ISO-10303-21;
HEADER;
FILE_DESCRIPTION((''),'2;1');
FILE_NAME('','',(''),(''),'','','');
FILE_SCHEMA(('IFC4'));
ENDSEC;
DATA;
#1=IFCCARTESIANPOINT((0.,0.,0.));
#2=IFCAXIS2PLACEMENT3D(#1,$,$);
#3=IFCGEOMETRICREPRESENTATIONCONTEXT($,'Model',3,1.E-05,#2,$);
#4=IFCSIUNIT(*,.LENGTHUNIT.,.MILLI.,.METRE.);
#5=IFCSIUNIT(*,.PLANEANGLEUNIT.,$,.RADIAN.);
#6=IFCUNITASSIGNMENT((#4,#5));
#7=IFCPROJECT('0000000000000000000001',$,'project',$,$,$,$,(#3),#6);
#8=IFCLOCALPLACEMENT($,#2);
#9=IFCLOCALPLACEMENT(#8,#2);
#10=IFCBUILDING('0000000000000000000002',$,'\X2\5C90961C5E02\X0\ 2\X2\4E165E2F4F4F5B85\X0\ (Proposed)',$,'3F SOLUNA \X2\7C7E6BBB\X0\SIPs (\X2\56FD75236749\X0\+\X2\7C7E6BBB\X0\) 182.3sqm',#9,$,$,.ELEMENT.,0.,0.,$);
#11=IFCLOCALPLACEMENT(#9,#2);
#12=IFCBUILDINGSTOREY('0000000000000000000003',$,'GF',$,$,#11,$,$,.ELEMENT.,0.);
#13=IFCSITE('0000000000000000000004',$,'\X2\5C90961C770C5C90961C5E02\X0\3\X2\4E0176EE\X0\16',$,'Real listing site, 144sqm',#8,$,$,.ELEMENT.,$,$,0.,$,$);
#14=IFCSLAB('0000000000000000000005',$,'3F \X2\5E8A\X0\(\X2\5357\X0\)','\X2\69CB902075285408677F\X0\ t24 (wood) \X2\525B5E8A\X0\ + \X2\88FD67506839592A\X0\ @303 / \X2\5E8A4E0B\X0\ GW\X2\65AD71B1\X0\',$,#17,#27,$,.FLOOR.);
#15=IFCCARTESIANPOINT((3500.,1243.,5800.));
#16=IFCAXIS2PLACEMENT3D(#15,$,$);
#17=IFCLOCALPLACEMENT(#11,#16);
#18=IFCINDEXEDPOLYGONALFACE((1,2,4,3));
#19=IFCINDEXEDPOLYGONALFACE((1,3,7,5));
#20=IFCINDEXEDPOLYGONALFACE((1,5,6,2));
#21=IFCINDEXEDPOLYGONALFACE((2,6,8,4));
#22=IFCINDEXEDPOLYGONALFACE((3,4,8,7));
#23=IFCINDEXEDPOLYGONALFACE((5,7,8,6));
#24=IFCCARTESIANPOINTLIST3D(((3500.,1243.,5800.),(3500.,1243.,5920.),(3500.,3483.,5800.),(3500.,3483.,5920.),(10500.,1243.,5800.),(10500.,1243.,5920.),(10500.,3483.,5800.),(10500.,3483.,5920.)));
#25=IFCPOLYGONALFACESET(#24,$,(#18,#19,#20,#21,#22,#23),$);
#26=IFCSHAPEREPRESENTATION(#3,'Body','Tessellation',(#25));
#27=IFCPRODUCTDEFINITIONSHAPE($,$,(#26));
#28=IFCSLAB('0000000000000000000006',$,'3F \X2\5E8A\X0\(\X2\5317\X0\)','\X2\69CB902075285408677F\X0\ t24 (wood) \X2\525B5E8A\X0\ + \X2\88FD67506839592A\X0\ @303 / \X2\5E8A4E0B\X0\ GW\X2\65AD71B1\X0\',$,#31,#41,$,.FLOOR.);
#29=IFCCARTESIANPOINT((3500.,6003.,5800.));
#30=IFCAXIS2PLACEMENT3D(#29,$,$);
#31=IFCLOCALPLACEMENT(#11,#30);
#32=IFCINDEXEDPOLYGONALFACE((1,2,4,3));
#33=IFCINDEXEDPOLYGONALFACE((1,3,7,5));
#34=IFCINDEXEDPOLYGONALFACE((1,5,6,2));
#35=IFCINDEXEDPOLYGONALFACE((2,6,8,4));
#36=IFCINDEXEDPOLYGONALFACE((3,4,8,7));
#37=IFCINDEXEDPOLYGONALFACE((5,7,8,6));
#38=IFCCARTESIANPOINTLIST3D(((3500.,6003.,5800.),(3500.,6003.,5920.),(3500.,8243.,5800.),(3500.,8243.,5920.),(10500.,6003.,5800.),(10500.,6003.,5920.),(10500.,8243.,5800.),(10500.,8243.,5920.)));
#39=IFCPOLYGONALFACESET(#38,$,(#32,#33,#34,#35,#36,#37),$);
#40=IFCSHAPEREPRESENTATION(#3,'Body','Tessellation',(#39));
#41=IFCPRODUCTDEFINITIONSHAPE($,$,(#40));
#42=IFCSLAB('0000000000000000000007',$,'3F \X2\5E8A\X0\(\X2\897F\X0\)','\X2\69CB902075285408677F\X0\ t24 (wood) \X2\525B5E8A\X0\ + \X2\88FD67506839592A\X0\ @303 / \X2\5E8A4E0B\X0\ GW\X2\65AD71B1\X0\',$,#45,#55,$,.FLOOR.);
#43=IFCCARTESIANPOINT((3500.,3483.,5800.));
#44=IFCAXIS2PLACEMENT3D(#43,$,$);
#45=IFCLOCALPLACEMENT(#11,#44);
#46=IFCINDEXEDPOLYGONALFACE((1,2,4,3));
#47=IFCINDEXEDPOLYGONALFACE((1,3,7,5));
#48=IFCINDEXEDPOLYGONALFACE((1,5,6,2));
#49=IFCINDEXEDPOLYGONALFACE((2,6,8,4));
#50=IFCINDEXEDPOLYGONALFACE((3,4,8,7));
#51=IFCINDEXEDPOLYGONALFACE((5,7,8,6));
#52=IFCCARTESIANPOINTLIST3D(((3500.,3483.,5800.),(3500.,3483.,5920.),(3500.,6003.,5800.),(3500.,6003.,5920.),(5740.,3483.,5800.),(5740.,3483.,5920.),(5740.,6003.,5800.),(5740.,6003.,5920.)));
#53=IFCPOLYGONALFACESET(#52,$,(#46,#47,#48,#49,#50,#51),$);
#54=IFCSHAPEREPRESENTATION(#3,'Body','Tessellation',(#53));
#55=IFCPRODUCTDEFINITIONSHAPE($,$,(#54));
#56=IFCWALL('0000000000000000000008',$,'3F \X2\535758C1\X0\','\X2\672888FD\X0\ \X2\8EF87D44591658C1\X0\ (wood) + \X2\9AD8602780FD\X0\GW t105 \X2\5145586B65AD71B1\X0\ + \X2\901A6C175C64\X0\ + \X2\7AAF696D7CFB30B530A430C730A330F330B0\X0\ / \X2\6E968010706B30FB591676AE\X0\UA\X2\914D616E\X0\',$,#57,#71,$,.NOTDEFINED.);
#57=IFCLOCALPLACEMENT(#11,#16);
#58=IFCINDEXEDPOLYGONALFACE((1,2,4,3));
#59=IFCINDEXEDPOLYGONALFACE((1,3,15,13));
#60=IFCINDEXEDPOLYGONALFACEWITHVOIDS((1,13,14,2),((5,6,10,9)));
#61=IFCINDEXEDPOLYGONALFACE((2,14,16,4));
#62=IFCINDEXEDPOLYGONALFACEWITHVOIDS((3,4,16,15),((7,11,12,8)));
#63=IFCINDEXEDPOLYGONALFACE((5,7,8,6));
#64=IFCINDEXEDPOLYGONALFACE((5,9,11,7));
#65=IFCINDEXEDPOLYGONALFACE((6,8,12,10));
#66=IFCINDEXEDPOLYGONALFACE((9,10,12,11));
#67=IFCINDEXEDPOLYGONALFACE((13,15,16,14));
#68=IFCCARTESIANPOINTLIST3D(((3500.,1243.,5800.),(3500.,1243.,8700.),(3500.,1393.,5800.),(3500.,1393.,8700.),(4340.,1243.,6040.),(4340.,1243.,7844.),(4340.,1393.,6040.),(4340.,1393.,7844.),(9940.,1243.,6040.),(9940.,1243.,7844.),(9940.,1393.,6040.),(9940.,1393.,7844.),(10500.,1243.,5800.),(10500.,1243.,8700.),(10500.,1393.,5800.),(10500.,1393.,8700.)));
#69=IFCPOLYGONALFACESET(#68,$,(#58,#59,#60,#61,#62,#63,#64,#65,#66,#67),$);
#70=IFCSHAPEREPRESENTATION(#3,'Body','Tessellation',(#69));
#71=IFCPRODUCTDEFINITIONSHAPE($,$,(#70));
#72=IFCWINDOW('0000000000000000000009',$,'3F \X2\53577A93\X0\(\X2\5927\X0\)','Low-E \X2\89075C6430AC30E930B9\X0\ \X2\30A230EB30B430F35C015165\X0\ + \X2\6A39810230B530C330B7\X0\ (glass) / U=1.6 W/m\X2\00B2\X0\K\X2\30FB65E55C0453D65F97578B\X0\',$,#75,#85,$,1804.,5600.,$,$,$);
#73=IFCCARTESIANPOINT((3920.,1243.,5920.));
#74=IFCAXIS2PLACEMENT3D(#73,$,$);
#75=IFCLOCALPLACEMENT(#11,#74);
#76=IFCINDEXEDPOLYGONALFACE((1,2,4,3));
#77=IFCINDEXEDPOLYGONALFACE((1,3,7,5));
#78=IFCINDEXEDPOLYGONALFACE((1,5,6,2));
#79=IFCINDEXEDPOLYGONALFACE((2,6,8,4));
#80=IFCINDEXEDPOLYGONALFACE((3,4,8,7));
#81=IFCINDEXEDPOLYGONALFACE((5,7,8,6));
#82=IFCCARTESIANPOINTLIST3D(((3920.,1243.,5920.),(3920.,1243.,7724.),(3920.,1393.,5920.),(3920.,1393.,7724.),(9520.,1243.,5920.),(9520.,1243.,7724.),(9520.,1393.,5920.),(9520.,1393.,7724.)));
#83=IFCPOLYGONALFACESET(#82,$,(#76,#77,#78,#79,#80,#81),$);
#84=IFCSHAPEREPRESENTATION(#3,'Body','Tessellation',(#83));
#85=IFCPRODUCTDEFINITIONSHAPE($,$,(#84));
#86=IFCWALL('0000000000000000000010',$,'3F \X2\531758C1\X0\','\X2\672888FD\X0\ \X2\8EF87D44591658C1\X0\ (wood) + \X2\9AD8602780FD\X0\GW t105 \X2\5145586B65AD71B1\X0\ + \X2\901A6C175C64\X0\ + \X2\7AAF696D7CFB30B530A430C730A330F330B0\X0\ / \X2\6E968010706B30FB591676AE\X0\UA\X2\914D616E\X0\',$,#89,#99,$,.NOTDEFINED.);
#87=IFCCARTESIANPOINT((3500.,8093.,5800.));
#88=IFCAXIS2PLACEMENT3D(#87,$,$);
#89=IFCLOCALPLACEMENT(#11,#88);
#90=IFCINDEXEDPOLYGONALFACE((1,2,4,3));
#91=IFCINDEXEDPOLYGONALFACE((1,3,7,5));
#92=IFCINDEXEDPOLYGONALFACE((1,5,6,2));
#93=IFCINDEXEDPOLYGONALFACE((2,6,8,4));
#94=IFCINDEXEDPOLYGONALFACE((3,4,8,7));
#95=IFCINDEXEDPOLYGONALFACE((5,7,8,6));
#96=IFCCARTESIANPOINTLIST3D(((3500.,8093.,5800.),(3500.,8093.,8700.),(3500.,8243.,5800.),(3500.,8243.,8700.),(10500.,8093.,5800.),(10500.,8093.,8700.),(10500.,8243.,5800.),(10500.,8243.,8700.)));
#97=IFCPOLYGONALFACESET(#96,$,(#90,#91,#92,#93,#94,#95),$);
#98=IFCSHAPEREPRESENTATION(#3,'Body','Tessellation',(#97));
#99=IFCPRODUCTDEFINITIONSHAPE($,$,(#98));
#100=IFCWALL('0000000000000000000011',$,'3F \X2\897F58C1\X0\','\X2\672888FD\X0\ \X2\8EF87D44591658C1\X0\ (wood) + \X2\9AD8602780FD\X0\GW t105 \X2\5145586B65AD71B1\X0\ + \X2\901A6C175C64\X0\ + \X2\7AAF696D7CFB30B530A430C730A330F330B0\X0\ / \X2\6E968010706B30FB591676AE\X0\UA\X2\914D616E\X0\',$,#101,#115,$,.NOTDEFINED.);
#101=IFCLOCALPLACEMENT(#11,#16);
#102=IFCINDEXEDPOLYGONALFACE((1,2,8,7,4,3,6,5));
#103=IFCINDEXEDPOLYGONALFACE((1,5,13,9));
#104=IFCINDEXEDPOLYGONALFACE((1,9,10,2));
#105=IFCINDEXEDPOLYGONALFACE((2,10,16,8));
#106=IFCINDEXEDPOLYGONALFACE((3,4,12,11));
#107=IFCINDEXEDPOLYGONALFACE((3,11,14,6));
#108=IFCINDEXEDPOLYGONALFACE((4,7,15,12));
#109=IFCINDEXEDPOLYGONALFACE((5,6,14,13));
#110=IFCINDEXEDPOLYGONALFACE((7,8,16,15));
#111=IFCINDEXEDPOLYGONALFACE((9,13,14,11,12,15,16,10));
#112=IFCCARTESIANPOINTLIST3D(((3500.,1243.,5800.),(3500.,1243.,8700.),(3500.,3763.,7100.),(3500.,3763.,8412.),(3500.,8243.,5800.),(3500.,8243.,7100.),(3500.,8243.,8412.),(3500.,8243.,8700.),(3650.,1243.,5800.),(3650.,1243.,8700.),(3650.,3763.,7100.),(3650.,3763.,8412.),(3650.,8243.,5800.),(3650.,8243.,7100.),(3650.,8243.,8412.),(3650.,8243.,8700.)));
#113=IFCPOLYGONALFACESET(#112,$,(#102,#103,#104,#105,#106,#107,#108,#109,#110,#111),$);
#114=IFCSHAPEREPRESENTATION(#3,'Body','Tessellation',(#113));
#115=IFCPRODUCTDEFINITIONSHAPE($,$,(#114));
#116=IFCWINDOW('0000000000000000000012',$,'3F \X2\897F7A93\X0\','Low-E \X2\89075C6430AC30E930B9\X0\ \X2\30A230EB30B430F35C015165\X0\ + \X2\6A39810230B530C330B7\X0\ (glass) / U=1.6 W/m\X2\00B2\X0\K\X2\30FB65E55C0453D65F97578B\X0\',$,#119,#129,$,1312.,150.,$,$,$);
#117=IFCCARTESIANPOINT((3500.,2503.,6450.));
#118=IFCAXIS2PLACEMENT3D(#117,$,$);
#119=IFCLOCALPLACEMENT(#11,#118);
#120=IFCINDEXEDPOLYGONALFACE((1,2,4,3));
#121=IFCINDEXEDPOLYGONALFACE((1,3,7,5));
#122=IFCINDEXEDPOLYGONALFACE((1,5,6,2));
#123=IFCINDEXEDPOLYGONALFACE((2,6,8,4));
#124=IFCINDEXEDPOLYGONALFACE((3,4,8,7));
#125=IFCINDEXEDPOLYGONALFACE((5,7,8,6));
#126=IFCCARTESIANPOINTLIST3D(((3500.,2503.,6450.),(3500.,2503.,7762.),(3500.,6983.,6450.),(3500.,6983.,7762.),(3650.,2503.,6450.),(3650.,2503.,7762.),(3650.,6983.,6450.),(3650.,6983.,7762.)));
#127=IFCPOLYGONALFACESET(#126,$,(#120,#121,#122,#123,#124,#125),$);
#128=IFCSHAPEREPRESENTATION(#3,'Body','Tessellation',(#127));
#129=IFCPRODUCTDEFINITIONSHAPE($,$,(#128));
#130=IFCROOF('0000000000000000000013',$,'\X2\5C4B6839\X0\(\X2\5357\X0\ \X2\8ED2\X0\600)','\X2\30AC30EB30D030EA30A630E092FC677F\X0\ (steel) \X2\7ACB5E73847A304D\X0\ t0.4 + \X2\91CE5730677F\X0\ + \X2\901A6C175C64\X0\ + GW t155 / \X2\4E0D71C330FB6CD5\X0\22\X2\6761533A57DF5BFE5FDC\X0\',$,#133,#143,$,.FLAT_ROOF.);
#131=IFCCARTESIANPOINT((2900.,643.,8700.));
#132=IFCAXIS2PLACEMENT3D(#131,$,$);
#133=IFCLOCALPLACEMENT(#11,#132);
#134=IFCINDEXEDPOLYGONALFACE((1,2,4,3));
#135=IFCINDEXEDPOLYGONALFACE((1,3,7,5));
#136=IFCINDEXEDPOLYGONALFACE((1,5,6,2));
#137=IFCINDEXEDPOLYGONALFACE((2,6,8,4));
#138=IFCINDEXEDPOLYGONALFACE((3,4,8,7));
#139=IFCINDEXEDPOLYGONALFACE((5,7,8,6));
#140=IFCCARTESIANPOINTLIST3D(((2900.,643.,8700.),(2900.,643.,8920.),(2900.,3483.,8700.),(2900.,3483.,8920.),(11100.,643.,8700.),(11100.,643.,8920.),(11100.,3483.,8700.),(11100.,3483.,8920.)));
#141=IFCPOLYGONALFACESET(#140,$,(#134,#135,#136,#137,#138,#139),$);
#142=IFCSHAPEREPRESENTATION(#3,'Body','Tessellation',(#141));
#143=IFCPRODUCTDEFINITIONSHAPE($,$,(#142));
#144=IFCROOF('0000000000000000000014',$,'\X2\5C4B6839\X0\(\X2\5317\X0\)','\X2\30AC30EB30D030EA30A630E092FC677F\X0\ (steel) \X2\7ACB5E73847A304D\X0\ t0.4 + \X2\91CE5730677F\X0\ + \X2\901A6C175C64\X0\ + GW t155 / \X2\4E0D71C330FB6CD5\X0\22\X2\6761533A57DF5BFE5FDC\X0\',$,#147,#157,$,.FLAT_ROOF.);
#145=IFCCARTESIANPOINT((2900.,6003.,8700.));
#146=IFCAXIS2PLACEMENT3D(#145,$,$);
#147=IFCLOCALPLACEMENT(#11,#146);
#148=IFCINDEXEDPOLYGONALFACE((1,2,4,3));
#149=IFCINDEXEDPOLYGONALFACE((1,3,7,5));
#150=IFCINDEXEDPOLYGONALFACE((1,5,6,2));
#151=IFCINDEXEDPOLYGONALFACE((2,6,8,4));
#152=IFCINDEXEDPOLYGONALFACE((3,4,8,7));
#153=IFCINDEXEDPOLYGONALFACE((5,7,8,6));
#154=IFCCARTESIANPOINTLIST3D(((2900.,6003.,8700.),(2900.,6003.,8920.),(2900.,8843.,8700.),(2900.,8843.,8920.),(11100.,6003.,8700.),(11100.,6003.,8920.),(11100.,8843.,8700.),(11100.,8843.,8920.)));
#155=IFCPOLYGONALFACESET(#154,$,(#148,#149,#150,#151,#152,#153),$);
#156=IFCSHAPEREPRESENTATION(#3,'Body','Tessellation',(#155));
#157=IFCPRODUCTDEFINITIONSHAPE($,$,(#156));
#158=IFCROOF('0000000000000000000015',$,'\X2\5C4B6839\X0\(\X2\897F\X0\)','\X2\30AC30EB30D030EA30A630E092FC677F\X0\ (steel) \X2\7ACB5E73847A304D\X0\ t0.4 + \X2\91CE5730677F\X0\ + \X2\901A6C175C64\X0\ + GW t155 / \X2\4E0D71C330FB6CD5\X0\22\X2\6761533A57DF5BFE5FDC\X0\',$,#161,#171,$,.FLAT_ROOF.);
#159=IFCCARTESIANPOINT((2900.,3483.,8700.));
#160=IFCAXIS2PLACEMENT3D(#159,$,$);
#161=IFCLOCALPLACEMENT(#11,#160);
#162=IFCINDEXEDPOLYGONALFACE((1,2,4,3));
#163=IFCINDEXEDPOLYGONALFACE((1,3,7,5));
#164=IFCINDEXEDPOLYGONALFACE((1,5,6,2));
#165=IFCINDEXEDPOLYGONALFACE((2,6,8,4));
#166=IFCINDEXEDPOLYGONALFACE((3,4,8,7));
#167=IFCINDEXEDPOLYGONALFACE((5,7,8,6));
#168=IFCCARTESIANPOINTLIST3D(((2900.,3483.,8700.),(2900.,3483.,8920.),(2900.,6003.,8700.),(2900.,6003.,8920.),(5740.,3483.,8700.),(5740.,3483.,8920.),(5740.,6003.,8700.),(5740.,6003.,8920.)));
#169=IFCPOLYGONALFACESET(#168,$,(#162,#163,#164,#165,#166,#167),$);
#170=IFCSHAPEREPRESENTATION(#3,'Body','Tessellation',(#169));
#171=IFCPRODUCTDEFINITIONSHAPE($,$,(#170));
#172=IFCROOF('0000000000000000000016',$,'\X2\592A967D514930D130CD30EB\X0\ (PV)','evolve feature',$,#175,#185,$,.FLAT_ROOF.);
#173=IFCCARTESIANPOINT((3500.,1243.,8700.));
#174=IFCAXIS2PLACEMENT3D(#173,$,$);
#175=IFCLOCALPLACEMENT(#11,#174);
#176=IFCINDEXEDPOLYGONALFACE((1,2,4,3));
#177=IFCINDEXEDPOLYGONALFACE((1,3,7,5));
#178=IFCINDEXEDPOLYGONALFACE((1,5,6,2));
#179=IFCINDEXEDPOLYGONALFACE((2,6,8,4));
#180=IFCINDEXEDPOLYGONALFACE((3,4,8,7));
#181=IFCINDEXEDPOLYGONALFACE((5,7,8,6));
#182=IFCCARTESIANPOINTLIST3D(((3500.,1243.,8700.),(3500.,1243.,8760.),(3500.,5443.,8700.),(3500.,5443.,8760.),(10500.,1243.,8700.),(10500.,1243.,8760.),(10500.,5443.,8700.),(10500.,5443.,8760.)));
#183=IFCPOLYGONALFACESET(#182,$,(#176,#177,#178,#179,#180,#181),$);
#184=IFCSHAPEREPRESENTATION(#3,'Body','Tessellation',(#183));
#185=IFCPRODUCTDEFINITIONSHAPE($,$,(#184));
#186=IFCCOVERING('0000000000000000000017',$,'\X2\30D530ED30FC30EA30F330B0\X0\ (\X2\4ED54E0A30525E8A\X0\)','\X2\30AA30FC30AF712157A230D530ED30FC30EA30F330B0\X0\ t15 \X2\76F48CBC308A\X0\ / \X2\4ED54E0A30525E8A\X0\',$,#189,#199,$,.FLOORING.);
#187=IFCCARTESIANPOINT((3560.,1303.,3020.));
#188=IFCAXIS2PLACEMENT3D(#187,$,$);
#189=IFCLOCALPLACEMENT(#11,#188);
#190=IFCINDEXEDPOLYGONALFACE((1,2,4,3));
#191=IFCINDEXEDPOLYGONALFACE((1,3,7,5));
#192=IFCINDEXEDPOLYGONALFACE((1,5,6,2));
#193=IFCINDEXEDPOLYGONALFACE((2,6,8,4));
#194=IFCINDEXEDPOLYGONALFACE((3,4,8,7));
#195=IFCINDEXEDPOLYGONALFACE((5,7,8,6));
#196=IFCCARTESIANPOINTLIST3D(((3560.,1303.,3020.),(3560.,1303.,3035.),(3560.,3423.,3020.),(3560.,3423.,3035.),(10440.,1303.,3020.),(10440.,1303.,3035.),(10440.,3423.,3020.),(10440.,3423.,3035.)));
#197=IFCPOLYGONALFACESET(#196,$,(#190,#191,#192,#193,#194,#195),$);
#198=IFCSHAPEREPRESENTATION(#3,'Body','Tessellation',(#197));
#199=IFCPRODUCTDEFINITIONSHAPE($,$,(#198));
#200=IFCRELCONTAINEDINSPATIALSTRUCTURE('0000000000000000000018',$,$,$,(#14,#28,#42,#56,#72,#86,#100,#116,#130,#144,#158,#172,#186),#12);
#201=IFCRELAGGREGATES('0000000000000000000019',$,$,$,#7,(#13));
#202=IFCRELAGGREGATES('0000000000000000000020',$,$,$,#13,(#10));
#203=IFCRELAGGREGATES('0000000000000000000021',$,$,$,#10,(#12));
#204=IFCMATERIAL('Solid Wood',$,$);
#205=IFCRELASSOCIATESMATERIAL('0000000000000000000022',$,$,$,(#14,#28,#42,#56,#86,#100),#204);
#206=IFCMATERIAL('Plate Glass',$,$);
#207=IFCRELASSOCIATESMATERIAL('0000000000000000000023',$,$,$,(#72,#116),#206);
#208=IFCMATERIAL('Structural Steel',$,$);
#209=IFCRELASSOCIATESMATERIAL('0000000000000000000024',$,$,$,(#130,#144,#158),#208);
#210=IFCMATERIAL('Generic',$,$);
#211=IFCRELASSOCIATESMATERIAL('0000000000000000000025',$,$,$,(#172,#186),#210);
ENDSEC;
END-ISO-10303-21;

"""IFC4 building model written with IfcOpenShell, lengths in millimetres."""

from ifc_helpers import new_model, si_unit, frame, frame_2d, origin, place, context, project, spatial, rectangle, extrude, material, element, fill, save


model = new_model("IFC4")

# Units and contexts
model_context = context("Model", 3, precision=1e-05, world=origin())
ifc_project = project(units=[si_unit("LENGTHUNIT", "METRE", prefix="MILLI"), si_unit("PLANEANGLEUNIT", "RADIAN")], contexts=[model_context])

# Site, building, storey
site_placement = place(None, origin())
site = spatial("IfcSite", under=ifc_project, at=site_placement, Name="岐阜県岐阜市3丁目16", ObjectType="Real listing site, 144sqm", CompositionType="ELEMENT", RefElevation=0.0)
building_placement = place(site_placement, origin())
building = spatial("IfcBuilding", under=site, at=building_placement, Name="岐阜市 2世帯住宅 (Proposed)", ObjectType="3F SOLUNA 籾殻SIPs (国産杉+籾殻) 182.3sqm", CompositionType="ELEMENT", ElevationOfRefHeight=0.0, ElevationOfTerrain=0.0)
storey_placement = place(building_placement, origin())
storey = spatial("IfcBuildingStorey", under=building, at=storey_placement, Name="GF", CompositionType="ELEMENT", Elevation=0.0)

# Slabs
ifc_material_1 = material(Name="Solid Wood")
slab_1_placement = place(storey_placement, frame((3500.0, 1243.0, 5800.0)))
element("IfcSlab", 1, at=slab_1_placement, inside=storey, material=ifc_material_1, Name="3F 床(南)", Description="構造用合板 t24 (wood) 剛床 + 製材根太 @303 / 床下 GW断熱", PredefinedType="FLOOR", context=model_context, shape_type="SweptSolid", body=[
    extrude(rectangle(XDim=7000.0, YDim=2240.0, at=frame_2d((3500.0, 1120.0))), frame((3500.0, 1243.0, 5800.0)), (0.0, 0.0, 1.0), 120.0),
])
slab_2_placement = place(storey_placement, frame((3500.0, 6003.0, 5800.0)))
element("IfcSlab", 2, at=slab_2_placement, inside=storey, material=ifc_material_1, Name="3F 床(北)", Description="構造用合板 t24 (wood) 剛床 + 製材根太 @303 / 床下 GW断熱", PredefinedType="FLOOR", context=model_context, shape_type="SweptSolid", body=[
    extrude(rectangle(XDim=7000.0, YDim=2240.0, at=frame_2d((3500.0, 1120.0))), frame((3500.0, 6003.0, 5800.0)), (0.0, 0.0, 1.0), 120.0),
])
slab_3_placement = place(storey_placement, frame((3500.0, 3483.0, 5800.0)))
element("IfcSlab", 3, at=slab_3_placement, inside=storey, material=ifc_material_1, Name="3F 床(西)", Description="構造用合板 t24 (wood) 剛床 + 製材根太 @303 / 床下 GW断熱", PredefinedType="FLOOR", context=model_context, shape_type="SweptSolid", body=[
    extrude(rectangle(XDim=2240.0, YDim=2520.0, at=frame_2d((1120.0, 1260.0))), frame((3500.0, 3483.0, 5800.0)), (0.0, 0.0, 1.0), 120.0),
])

# Wall, opening, window
wall_1_placement = place(storey_placement, frame((3500.0, 1243.0, 5800.0)))
wall_1 = element("IfcWall", 4, at=wall_1_placement, inside=storey, material=ifc_material_1, Name="3F 南壁", Description="木製 軸組外壁 (wood) + 高性能GW t105 充填断熱 + 通気層 + 窯業系サイディング / 準耐火・外皮UA配慮", PredefinedType="NOTDEFINED", context=model_context, shape_type="SweptSolid", body=[
    extrude(rectangle(XDim=7000.0, YDim=150.0, at=frame_2d((3500.0, 75.0))), frame((3500.0, 1243.0, 5800.0)), (0.0, 0.0, 1.0), 2900.0),
])
opening_1_placement = place(storey_placement, frame((3920.0, 1243.0, 5920.0)))
opening_1 = element("IfcOpeningElement", 5, at=opening_1_placement, cuts=wall_1, PredefinedType="NOTDEFINED", context=model_context, shape_type="SweptSolid", body=[
    extrude(rectangle(XDim=5600.0, YDim=150.0, at=frame_2d((2800.0, 75.0))), frame((3920.0, 1243.0, 5920.0)), (0.0, 0.0, 1.0), 1804.0),
])
ifc_material_2 = material(Name="Plate Glass")
window_1_placement = place(storey_placement, frame((3920.0, 1243.0, 5920.0)))
window_1 = element("IfcWindow", 6, at=window_1_placement, inside=storey, material=ifc_material_2, Name="3F 南窓(大)", Description="Low-E 複層ガラス アルゴン封入 + 樹脂サッシ (glass) / U=1.6 W/m²K・日射取得型", OverallHeight=1804.0, OverallWidth=5600.0, context=model_context, shape_type="SweptSolid", body=[
    extrude(rectangle(XDim=5600.0, YDim=150.0, at=frame_2d((2800.0, 75.0))), frame((3920.0, 1243.0, 5920.0)), (0.0, 0.0, 1.0), 1804.0),
])
fill(opening_1, window_1)

# Wall
wall_2_placement = place(storey_placement, frame((3500.0, 8093.0, 5800.0)))
element("IfcWall", 7, at=wall_2_placement, inside=storey, material=ifc_material_1, Name="3F 北壁", Description="木製 軸組外壁 (wood) + 高性能GW t105 充填断熱 + 通気層 + 窯業系サイディング / 準耐火・外皮UA配慮", PredefinedType="NOTDEFINED", context=model_context, shape_type="SweptSolid", body=[
    extrude(rectangle(XDim=7000.0, YDim=150.0, at=frame_2d((3500.0, 75.0))), frame((3500.0, 8093.0, 5800.0)), (0.0, 0.0, 1.0), 2900.0),
])

# Wall, opening, window
wall_3_placement = place(storey_placement, frame((3500.0, 1243.0, 5800.0)))
wall_3 = element("IfcWall", 8, at=wall_3_placement, inside=storey, material=ifc_material_1, Name="3F 西壁", Description="木製 軸組外壁 (wood) + 高性能GW t105 充填断熱 + 通気層 + 窯業系サイディング / 準耐火・外皮UA配慮", PredefinedType="NOTDEFINED", context=model_context, shape_type="SweptSolid", body=[
    extrude(rectangle(XDim=150.0, YDim=7000.0, at=frame_2d((75.0, 3500.0))), frame((3500.0, 1243.0, 5800.0)), (0.0, 0.0, 1.0), 2900.0),
])
opening_2_placement = place(storey_placement, frame((3500.0, 2503.0, 6450.0)))
opening_2 = element("IfcOpeningElement", 9, at=opening_2_placement, cuts=wall_3, PredefinedType="NOTDEFINED", context=model_context, shape_type="SweptSolid", body=[
    extrude(rectangle(XDim=150.0, YDim=4480.0, at=frame_2d((75.0, 2240.0))), frame((3500.0, 2503.0, 6450.0)), (0.0, 0.0, 1.0), 1312.0),
])
window_2_placement = place(storey_placement, frame((3500.0, 2503.0, 6450.0)))
window_2 = element("IfcWindow", 10, at=window_2_placement, inside=storey, material=ifc_material_2, Name="3F 西窓", Description="Low-E 複層ガラス アルゴン封入 + 樹脂サッシ (glass) / U=1.6 W/m²K・日射取得型", OverallHeight=1312.0, OverallWidth=150.0, context=model_context, shape_type="SweptSolid", body=[
    extrude(rectangle(XDim=150.0, YDim=4480.0, at=frame_2d((75.0, 2240.0))), frame((3500.0, 2503.0, 6450.0)), (0.0, 0.0, 1.0), 1312.0),
])
fill(opening_2, window_2)

# Roofs
ifc_material_3 = material(Name="Structural Steel")
roof_1_placement = place(storey_placement, frame((2900.0, 643.0, 8700.0)))
element("IfcRoof", 11, at=roof_1_placement, inside=storey, material=ifc_material_3, Name="屋根(南 軒600)", Description="ガルバリウム鋼板 (steel) 立平葺き t0.4 + 野地板 + 通気層 + GW t155 / 不燃・法22条区域対応", PredefinedType="FLAT_ROOF", context=model_context, shape_type="SweptSolid", body=[
    extrude(rectangle(XDim=8200.0, YDim=2840.0, at=frame_2d((4100.0, 1420.0))), frame((2900.0, 643.0, 8700.0)), (0.0, 0.0, 1.0), 220.0),
])
roof_2_placement = place(storey_placement, frame((2900.0, 6003.0, 8700.0)))
element("IfcRoof", 12, at=roof_2_placement, inside=storey, material=ifc_material_3, Name="屋根(北)", Description="ガルバリウム鋼板 (steel) 立平葺き t0.4 + 野地板 + 通気層 + GW t155 / 不燃・法22条区域対応", PredefinedType="FLAT_ROOF", context=model_context, shape_type="SweptSolid", body=[
    extrude(rectangle(XDim=8200.0, YDim=2840.0, at=frame_2d((4100.0, 1420.0))), frame((2900.0, 6003.0, 8700.0)), (0.0, 0.0, 1.0), 220.0),
])
roof_3_placement = place(storey_placement, frame((2900.0, 3483.0, 8700.0)))
element("IfcRoof", 13, at=roof_3_placement, inside=storey, material=ifc_material_3, Name="屋根(西)", Description="ガルバリウム鋼板 (steel) 立平葺き t0.4 + 野地板 + 通気層 + GW t155 / 不燃・法22条区域対応", PredefinedType="FLAT_ROOF", context=model_context, shape_type="SweptSolid", body=[
    extrude(rectangle(XDim=2840.0, YDim=2520.0, at=frame_2d((1420.0, 1260.0))), frame((2900.0, 3483.0, 8700.0)), (0.0, 0.0, 1.0), 220.0),
])
ifc_material_4 = material(Name="Generic")
roof_4_placement = place(storey_placement, frame((3500.0, 1243.0, 8700.0)))
element("IfcRoof", 14, at=roof_4_placement, inside=storey, material=ifc_material_4, Name="太陽光パネル (PV)", Description="evolve feature", PredefinedType="FLAT_ROOF", context=model_context, shape_type="SweptSolid", body=[
    extrude(rectangle(XDim=7000.0, YDim=4200.0, at=frame_2d((3500.0, 2100.0))), frame((3500.0, 1243.0, 8700.0)), (0.0, 0.0, 1.0), 60.0),
])

# Covering
covering_1_placement = place(storey_placement, frame((3560.0, 1303.0, 3020.0)))
element("IfcCovering", 15, at=covering_1_placement, inside=storey, material=ifc_material_4, Name="フローリング (仕上げ床)", Description="オーク無垢フローリング t15 直貼り / 仕上げ床", PredefinedType="FLOORING", context=model_context, shape_type="SweptSolid", body=[
    extrude(rectangle(XDim=6880.0, YDim=2120.0, at=frame_2d((3440.0, 1060.0))), frame((3560.0, 1303.0, 3020.0)), (0.0, 0.0, 1.0), 15.0),
])

save(model, "model.ifc")
